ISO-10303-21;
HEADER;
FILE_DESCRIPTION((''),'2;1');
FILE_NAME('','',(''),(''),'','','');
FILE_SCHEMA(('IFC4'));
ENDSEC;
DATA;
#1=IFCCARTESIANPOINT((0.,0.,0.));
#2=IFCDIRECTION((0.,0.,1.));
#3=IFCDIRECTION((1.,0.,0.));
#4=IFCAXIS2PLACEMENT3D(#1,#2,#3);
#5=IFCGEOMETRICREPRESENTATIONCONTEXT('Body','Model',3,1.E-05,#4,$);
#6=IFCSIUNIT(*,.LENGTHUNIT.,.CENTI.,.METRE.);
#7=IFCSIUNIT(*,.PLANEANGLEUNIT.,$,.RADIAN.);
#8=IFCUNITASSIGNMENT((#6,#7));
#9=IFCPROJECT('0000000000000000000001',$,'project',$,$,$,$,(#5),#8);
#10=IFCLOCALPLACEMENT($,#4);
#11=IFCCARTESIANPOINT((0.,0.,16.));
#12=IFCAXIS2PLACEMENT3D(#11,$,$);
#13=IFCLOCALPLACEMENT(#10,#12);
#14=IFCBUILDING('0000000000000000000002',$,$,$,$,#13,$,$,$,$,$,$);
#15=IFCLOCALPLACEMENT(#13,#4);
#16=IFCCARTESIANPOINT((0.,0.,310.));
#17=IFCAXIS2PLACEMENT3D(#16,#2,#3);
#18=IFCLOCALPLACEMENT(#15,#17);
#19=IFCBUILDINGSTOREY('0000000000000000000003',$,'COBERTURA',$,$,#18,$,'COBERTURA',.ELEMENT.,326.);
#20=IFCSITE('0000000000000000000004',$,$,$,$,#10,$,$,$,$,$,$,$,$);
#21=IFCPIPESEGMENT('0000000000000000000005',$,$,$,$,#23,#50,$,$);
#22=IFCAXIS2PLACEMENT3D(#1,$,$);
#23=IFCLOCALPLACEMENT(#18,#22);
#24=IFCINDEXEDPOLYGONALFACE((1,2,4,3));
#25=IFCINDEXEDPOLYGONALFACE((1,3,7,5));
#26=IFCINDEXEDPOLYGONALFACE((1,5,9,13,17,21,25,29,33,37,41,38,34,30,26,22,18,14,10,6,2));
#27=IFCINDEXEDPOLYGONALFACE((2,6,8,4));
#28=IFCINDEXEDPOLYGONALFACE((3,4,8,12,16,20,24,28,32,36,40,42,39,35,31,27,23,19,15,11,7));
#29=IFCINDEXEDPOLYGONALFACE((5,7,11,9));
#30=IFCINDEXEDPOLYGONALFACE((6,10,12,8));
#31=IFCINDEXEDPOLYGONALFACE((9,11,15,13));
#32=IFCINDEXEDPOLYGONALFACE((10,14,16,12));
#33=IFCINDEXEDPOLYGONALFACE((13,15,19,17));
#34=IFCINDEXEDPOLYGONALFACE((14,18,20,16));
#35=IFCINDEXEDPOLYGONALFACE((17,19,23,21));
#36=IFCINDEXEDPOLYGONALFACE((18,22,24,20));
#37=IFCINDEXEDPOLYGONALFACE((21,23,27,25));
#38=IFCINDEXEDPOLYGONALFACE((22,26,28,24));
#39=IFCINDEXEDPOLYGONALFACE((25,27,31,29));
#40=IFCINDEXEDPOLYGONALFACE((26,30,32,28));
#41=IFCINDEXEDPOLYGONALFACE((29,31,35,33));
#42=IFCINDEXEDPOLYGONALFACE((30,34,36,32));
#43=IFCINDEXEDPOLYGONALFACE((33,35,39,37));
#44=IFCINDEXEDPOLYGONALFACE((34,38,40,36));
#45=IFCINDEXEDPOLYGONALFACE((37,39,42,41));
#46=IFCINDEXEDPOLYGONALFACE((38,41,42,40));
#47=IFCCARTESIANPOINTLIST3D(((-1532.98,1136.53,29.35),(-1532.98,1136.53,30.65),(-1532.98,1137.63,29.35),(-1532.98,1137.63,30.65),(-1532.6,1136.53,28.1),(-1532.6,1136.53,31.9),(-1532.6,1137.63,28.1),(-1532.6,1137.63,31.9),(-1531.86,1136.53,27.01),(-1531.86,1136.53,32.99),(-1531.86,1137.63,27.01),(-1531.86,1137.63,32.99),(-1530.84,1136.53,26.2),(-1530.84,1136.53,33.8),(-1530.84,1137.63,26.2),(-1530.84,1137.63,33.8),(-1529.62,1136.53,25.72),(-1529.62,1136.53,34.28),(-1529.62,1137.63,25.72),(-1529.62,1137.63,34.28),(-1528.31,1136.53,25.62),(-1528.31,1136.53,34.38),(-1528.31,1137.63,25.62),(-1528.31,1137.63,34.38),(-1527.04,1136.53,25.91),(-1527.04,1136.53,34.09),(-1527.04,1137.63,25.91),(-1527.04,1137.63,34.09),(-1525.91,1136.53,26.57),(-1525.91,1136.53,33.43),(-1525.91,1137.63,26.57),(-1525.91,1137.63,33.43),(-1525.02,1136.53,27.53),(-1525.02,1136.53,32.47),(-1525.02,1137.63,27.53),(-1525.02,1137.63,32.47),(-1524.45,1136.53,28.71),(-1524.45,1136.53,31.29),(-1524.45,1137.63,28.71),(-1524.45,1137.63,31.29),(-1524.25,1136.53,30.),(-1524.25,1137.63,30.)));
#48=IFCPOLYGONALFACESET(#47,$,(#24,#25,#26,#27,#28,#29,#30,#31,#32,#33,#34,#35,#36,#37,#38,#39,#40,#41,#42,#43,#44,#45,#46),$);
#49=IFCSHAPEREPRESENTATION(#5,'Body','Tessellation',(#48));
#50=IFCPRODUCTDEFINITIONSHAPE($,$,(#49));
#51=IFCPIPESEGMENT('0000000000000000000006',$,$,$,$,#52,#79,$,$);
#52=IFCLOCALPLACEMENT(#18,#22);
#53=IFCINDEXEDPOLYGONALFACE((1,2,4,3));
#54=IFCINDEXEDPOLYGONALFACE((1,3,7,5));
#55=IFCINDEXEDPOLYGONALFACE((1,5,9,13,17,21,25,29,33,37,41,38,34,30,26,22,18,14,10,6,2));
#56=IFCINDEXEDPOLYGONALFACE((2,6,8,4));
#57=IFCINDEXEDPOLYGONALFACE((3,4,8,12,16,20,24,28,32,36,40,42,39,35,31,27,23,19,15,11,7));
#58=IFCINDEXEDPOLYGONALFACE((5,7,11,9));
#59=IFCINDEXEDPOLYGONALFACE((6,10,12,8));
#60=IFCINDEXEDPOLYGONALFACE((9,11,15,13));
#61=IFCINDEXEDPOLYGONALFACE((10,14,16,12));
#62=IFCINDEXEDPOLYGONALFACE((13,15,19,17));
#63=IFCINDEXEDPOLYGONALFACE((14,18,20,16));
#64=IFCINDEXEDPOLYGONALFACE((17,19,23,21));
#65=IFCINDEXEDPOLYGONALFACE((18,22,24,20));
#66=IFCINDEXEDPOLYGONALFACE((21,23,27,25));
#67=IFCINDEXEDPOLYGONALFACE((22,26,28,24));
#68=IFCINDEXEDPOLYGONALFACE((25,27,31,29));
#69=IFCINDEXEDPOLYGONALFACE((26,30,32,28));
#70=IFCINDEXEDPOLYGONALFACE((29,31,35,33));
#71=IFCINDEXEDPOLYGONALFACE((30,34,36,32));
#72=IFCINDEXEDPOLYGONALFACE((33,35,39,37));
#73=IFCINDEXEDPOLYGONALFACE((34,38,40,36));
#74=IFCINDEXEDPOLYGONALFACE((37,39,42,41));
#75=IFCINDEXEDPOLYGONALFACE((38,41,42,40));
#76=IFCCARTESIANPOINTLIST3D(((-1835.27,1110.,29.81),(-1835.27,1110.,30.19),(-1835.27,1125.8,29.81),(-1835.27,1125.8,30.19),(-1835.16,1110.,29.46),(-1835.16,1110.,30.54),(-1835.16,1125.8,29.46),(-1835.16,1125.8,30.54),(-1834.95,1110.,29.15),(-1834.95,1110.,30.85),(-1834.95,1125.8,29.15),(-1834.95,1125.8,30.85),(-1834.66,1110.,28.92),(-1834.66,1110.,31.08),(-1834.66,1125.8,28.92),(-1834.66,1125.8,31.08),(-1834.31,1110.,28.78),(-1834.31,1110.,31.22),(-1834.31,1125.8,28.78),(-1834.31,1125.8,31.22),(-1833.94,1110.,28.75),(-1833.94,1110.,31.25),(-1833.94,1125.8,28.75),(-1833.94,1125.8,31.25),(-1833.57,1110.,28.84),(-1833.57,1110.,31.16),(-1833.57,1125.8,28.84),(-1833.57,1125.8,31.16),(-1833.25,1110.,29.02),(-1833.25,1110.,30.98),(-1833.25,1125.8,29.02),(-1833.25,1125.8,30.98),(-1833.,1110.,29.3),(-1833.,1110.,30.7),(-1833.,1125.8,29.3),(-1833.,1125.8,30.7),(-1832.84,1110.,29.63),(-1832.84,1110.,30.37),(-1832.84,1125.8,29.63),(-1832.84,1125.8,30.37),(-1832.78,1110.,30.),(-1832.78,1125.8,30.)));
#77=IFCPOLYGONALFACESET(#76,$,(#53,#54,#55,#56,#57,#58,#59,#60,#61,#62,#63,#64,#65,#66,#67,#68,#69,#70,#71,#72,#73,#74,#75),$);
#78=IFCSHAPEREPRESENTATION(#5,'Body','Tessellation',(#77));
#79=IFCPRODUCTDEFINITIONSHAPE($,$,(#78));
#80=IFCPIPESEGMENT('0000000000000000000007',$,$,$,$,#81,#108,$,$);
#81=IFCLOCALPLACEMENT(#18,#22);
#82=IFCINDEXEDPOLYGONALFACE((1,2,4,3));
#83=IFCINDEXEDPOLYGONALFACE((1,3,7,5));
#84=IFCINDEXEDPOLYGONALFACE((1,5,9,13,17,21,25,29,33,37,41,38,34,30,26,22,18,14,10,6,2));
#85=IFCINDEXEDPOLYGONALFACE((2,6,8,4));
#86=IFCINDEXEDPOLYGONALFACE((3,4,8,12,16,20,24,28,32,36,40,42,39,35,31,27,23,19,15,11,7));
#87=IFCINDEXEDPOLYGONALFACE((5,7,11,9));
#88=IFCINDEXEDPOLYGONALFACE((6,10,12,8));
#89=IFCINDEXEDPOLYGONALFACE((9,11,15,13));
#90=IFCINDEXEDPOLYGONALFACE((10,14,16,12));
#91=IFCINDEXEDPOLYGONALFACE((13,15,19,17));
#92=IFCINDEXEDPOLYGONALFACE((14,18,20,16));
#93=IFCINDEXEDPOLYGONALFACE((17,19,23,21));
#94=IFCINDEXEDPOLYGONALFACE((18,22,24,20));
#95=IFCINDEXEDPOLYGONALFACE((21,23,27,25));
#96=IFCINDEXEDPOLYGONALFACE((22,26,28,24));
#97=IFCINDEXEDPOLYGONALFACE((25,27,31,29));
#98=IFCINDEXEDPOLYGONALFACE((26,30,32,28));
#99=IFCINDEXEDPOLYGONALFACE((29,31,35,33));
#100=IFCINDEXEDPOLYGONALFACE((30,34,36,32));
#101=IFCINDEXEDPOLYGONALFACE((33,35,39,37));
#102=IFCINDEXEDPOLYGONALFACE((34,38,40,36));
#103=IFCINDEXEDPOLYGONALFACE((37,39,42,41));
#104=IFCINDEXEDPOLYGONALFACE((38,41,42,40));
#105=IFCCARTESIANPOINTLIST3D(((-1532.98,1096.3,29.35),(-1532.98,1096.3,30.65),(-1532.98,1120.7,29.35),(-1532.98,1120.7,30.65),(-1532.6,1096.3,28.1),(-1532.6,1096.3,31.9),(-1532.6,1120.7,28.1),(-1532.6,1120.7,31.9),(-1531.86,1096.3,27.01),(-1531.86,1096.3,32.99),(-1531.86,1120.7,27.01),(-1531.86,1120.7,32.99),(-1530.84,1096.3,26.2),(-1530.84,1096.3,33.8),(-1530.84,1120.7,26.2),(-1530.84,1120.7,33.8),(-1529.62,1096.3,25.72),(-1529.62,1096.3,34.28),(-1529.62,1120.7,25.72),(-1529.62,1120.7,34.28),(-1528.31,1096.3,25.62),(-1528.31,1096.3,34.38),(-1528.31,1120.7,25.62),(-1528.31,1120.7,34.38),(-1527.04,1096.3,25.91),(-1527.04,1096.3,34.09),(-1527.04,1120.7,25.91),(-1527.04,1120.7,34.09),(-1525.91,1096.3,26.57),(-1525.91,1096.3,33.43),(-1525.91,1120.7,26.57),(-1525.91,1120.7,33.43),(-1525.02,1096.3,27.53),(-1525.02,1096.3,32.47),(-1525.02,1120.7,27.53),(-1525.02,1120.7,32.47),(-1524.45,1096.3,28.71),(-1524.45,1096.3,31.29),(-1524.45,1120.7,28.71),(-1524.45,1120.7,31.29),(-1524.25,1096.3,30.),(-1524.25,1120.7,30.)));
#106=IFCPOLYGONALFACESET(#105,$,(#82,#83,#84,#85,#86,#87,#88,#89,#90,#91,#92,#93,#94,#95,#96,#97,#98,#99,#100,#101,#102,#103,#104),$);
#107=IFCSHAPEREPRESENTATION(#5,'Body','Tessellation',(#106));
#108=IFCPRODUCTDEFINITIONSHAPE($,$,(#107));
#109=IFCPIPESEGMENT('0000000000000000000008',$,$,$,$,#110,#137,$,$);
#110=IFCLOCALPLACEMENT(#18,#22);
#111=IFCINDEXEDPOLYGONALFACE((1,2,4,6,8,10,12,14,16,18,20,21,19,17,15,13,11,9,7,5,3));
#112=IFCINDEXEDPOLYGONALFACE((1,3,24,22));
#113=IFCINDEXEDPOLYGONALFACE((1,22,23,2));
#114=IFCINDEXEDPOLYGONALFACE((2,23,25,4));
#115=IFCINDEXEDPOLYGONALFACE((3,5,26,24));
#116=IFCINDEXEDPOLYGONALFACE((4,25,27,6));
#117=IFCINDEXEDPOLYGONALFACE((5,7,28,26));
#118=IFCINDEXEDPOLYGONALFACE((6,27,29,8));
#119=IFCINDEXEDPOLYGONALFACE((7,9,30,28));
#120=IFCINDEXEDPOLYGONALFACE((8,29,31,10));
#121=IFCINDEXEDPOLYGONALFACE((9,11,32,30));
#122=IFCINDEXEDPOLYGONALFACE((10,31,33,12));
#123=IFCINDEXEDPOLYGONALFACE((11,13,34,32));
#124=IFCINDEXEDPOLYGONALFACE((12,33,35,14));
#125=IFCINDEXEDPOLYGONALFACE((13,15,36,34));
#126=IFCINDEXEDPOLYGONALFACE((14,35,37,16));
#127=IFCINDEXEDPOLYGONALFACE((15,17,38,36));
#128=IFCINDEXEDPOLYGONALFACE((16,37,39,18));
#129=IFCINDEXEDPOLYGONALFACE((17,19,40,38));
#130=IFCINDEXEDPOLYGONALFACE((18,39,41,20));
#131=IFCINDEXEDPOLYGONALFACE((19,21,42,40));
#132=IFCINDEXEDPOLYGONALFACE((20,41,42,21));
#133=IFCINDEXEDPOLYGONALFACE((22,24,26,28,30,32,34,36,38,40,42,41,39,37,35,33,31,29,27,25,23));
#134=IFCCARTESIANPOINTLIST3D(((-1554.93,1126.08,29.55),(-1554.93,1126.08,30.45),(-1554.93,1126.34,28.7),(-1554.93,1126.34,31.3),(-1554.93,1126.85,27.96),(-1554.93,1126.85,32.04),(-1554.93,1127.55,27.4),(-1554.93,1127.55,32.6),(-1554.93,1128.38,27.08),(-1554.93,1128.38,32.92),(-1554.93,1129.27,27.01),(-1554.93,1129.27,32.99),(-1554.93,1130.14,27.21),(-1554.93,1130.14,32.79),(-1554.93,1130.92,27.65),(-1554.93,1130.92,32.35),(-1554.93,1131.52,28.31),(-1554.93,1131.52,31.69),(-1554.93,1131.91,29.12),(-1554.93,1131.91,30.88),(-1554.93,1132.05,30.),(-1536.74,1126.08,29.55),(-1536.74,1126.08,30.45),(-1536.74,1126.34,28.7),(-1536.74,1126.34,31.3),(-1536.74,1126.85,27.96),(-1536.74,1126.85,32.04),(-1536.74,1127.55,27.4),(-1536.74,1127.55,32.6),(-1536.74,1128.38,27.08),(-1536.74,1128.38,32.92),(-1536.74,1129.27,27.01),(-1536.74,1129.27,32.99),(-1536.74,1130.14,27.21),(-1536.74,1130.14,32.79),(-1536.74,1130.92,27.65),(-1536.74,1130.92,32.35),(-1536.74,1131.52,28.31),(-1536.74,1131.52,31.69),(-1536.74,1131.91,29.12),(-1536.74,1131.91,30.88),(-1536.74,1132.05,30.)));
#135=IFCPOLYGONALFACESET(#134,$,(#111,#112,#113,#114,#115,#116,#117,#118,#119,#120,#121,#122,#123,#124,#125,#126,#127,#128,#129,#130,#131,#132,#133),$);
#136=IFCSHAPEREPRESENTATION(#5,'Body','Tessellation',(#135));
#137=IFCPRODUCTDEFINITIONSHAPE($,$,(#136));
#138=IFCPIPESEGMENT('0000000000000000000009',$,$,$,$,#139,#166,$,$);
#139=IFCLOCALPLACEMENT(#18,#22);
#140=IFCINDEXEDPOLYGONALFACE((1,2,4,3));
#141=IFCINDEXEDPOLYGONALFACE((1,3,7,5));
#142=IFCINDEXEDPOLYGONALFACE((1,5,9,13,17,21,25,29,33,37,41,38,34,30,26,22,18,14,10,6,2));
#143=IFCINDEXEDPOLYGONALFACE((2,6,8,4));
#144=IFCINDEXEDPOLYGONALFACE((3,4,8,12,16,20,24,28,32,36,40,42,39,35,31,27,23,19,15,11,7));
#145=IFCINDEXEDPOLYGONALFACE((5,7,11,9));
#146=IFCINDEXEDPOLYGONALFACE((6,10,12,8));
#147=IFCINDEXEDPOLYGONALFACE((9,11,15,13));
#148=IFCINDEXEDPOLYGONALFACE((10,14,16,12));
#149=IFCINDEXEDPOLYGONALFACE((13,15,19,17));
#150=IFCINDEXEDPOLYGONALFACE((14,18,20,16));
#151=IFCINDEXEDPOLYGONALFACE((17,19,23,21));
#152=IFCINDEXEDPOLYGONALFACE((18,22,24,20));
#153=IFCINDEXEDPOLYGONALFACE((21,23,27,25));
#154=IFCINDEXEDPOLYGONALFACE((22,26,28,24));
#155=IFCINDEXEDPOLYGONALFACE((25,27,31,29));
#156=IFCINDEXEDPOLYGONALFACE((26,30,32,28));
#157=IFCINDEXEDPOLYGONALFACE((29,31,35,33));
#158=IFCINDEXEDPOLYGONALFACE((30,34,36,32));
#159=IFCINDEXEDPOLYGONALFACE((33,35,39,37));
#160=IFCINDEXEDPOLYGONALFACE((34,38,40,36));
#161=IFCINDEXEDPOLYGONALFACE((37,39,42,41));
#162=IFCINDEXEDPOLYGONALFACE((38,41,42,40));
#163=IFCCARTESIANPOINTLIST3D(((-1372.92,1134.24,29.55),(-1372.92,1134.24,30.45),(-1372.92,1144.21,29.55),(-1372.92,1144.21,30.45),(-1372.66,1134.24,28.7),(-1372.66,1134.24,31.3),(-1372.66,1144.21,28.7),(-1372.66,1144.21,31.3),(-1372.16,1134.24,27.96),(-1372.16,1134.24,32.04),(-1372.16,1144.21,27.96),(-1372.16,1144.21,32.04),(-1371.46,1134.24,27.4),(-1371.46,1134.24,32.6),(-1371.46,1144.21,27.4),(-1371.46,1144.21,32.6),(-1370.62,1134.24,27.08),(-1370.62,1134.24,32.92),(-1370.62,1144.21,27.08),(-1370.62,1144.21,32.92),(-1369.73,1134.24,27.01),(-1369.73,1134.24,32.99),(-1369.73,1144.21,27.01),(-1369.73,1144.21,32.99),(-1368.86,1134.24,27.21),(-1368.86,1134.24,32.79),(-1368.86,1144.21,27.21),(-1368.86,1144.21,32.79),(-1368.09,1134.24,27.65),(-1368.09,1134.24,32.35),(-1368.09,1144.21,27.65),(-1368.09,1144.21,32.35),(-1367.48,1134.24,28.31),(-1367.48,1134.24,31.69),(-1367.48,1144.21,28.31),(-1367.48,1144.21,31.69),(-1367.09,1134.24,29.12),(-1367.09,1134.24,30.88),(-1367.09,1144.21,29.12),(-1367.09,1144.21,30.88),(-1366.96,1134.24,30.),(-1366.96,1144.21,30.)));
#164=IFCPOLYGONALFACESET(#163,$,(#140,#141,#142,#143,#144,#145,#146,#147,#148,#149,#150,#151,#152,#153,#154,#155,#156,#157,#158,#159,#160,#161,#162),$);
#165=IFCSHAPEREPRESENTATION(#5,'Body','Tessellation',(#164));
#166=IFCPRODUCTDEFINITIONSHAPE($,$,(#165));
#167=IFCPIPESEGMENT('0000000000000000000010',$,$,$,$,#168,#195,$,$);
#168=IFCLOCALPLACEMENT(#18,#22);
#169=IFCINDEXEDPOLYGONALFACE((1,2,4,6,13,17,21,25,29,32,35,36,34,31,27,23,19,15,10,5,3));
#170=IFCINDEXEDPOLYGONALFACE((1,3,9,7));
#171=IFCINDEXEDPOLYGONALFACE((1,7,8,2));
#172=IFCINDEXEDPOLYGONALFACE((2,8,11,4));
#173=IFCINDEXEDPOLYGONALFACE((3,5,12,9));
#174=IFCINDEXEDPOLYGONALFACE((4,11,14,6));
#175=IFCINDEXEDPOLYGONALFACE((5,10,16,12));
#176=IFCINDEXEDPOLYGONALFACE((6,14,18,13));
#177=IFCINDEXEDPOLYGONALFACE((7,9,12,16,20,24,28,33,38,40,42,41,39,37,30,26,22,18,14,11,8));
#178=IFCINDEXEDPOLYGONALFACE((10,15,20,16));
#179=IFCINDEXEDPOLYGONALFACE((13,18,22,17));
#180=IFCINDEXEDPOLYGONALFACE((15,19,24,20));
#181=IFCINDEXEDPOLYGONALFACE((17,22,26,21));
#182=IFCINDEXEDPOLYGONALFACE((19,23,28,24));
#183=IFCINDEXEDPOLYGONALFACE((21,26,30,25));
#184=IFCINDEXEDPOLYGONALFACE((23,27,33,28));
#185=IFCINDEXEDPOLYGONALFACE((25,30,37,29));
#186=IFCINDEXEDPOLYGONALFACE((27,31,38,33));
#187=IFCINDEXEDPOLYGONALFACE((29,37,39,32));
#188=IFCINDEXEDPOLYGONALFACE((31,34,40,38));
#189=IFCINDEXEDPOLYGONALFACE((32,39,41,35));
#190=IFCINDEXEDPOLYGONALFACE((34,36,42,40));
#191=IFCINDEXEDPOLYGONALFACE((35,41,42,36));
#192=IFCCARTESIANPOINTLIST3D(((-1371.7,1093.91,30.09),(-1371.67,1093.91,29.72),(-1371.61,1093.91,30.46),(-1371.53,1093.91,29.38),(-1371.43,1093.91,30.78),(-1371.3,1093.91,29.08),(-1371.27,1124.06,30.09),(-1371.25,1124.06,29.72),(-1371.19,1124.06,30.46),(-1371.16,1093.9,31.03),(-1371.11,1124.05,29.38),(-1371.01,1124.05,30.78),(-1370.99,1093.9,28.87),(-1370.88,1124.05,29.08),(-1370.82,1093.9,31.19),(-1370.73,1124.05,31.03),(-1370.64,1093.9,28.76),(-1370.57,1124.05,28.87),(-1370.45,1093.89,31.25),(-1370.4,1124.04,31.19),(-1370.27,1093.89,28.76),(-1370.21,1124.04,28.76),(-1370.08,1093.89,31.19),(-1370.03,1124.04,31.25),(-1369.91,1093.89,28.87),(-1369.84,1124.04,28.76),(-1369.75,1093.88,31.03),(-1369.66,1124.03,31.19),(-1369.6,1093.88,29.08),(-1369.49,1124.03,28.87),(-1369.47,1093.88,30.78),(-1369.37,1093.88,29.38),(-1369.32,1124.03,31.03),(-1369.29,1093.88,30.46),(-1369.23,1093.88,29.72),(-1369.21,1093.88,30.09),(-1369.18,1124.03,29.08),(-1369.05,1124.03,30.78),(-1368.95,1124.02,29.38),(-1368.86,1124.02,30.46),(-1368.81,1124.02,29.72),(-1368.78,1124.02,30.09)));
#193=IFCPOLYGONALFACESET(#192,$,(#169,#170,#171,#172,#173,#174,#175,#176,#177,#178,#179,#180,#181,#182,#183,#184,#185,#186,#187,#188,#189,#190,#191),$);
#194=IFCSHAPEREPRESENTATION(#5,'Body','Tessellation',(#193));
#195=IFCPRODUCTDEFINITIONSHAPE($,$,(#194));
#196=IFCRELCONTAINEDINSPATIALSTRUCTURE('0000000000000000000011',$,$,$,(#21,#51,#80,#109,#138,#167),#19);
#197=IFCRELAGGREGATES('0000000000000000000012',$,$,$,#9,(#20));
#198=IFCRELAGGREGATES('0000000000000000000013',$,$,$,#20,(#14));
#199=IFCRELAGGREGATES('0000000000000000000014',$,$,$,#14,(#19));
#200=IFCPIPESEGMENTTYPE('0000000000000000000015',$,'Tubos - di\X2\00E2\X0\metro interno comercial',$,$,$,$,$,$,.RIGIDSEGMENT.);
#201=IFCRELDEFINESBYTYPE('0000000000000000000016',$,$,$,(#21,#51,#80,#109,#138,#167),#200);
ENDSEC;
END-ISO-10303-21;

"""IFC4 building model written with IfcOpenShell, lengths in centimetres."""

from ifc_helpers import new_model, si_unit, frame, origin_with_axes, origin_2d_with_axis, place, context, project, spatial, circle, extrude, type_object, element, save


model = new_model("IFC4")

# Units and contexts
model_context = context("Model", 3, precision=1e-05, world=origin_with_axes(), identifier="Body")
ifc_project = project(units=[si_unit("LENGTHUNIT", "METRE", prefix="CENTI"), si_unit("PLANEANGLEUNIT", "RADIAN")], contexts=[model_context])

# Site, building, storey
site_placement = place(None, origin_with_axes())
site = spatial("IfcSite", under=ifc_project, at=site_placement)
building_placement = place(site_placement, frame((0.0, 0.0, 16.0)))
building = spatial("IfcBuilding", under=site, at=building_placement)
placement = place(building_placement, origin_with_axes())
storey_placement = place(placement, frame((0.0, 0.0, 310.0), z_axis=(0.0, 0.0, 1.0), x_axis=(1.0, 0.0, 0.0)))
storey = spatial("IfcBuildingStorey", under=building, at=storey_placement, Name="COBERTURA", LongName="COBERTURA", CompositionType="ELEMENT", Elevation=326.0)

# Pipe segments
pipe_segment_type = type_object("IfcPipeSegmentType", Name="Tubos - diâmetro interno comercial", PredefinedType="RIGIDSEGMENT")
pipe_segment_1_placement = place(storey_placement, frame((-1528.64, 1137.08, 34.39), z_axis=(0.0, 0.0, 1.0), x_axis=(1.0, 0.0, 0.0)))
element("IfcPipeSegment", 1, at=pipe_segment_1_placement, inside=storey, type_object=pipe_segment_type, context=model_context, shape_type="SolidModel", body=[
    extrude(circle(Radius=4.39, at=origin_2d_with_axis()), frame((0.0, 0.55, -4.39), z_axis=(0.0, -1.0, 0.0), x_axis=(1.0, 0.0, 0.0)), (0.0, 0.0, 1.0), 1.1),
])
pipe_segment_2_placement = place(storey_placement, frame((-1834.03, 1117.9, 31.25), z_axis=(0.0, 0.0, 1.0), x_axis=(1.0, 0.0, 0.0)))
element("IfcPipeSegment", 2, at=pipe_segment_2_placement, inside=storey, type_object=pipe_segment_type, context=model_context, shape_type="SolidModel", body=[
    extrude(circle(Radius=1.25, at=origin_2d_with_axis()), frame((0.0, 7.9, -1.25), z_axis=(0.0, -1.0, 0.0), x_axis=(1.0, 0.0, 0.0)), (0.0, 0.0, 1.0), 15.79),
])
pipe_segment_3_placement = place(storey_placement, frame((-1528.64, 1108.5, 34.39), z_axis=(0.0, 0.0, 1.0), x_axis=(1.0, 0.0, 0.0)))
element("IfcPipeSegment", 3, at=pipe_segment_3_placement, inside=storey, type_object=pipe_segment_type, context=model_context, shape_type="SolidModel", body=[
    extrude(circle(Radius=4.39, at=origin_2d_with_axis()), frame((0.0, 12.2, -4.39), z_axis=(0.0, -1.0, 0.0), x_axis=(1.0, 0.0, 0.0)), (0.0, 0.0, 1.0), 24.39),
])
pipe_segment_4_placement = place(storey_placement, frame((-1545.84, 1129.05, 33.0), z_axis=(0.0, 0.0, 1.0), x_axis=(1.0, 0.0, 0.0)))
element("IfcPipeSegment", 4, at=pipe_segment_4_placement, inside=storey, type_object=pipe_segment_type, context=model_context, shape_type="SolidModel", body=[
    extrude(circle(Radius=3.0, at=origin_2d_with_axis()), frame((9.09, 0.0, -3.0), z_axis=(-1.0, 0.0, 0.0), x_axis=(0.0, 1.0, 0.0)), (0.0, 0.0, 1.0), 18.19),
])
pipe_segment_5_placement = place(storey_placement, frame((-1369.96, 1139.23, 33.0), z_axis=(0.0, 0.0, 1.0), x_axis=(1.0, 0.0, 0.0)))
element("IfcPipeSegment", 5, at=pipe_segment_5_placement, inside=storey, type_object=pipe_segment_type, context=model_context, shape_type="SolidModel", body=[
    extrude(circle(Radius=3.0, at=origin_2d_with_axis()), frame((0.0, 4.98, -3.0), z_axis=(0.0, -1.0, 0.0), x_axis=(1.0, 0.0, 0.0)), (0.0, 0.0, 1.0), 9.97),
])
pipe_segment_6_placement = place(storey_placement, frame((-1370.24, 1108.97, 31.25), z_axis=(0.0, 0.0, 1.0), x_axis=(1.0, 0.0, 0.0)))
element("IfcPipeSegment", 6, at=pipe_segment_6_placement, inside=storey, type_object=pipe_segment_type, context=model_context, shape_type="SolidModel", body=[
    extrude(circle(Radius=1.25, at=origin_2d_with_axis()), frame((0.21, 15.07, -1.25), z_axis=(-0.014045, -1.0, 0.0), x_axis=(0.0, 0.0, 1.0)), (0.0, 0.0, 1.0), 30.15),
])

save(model, "model.ifc")
